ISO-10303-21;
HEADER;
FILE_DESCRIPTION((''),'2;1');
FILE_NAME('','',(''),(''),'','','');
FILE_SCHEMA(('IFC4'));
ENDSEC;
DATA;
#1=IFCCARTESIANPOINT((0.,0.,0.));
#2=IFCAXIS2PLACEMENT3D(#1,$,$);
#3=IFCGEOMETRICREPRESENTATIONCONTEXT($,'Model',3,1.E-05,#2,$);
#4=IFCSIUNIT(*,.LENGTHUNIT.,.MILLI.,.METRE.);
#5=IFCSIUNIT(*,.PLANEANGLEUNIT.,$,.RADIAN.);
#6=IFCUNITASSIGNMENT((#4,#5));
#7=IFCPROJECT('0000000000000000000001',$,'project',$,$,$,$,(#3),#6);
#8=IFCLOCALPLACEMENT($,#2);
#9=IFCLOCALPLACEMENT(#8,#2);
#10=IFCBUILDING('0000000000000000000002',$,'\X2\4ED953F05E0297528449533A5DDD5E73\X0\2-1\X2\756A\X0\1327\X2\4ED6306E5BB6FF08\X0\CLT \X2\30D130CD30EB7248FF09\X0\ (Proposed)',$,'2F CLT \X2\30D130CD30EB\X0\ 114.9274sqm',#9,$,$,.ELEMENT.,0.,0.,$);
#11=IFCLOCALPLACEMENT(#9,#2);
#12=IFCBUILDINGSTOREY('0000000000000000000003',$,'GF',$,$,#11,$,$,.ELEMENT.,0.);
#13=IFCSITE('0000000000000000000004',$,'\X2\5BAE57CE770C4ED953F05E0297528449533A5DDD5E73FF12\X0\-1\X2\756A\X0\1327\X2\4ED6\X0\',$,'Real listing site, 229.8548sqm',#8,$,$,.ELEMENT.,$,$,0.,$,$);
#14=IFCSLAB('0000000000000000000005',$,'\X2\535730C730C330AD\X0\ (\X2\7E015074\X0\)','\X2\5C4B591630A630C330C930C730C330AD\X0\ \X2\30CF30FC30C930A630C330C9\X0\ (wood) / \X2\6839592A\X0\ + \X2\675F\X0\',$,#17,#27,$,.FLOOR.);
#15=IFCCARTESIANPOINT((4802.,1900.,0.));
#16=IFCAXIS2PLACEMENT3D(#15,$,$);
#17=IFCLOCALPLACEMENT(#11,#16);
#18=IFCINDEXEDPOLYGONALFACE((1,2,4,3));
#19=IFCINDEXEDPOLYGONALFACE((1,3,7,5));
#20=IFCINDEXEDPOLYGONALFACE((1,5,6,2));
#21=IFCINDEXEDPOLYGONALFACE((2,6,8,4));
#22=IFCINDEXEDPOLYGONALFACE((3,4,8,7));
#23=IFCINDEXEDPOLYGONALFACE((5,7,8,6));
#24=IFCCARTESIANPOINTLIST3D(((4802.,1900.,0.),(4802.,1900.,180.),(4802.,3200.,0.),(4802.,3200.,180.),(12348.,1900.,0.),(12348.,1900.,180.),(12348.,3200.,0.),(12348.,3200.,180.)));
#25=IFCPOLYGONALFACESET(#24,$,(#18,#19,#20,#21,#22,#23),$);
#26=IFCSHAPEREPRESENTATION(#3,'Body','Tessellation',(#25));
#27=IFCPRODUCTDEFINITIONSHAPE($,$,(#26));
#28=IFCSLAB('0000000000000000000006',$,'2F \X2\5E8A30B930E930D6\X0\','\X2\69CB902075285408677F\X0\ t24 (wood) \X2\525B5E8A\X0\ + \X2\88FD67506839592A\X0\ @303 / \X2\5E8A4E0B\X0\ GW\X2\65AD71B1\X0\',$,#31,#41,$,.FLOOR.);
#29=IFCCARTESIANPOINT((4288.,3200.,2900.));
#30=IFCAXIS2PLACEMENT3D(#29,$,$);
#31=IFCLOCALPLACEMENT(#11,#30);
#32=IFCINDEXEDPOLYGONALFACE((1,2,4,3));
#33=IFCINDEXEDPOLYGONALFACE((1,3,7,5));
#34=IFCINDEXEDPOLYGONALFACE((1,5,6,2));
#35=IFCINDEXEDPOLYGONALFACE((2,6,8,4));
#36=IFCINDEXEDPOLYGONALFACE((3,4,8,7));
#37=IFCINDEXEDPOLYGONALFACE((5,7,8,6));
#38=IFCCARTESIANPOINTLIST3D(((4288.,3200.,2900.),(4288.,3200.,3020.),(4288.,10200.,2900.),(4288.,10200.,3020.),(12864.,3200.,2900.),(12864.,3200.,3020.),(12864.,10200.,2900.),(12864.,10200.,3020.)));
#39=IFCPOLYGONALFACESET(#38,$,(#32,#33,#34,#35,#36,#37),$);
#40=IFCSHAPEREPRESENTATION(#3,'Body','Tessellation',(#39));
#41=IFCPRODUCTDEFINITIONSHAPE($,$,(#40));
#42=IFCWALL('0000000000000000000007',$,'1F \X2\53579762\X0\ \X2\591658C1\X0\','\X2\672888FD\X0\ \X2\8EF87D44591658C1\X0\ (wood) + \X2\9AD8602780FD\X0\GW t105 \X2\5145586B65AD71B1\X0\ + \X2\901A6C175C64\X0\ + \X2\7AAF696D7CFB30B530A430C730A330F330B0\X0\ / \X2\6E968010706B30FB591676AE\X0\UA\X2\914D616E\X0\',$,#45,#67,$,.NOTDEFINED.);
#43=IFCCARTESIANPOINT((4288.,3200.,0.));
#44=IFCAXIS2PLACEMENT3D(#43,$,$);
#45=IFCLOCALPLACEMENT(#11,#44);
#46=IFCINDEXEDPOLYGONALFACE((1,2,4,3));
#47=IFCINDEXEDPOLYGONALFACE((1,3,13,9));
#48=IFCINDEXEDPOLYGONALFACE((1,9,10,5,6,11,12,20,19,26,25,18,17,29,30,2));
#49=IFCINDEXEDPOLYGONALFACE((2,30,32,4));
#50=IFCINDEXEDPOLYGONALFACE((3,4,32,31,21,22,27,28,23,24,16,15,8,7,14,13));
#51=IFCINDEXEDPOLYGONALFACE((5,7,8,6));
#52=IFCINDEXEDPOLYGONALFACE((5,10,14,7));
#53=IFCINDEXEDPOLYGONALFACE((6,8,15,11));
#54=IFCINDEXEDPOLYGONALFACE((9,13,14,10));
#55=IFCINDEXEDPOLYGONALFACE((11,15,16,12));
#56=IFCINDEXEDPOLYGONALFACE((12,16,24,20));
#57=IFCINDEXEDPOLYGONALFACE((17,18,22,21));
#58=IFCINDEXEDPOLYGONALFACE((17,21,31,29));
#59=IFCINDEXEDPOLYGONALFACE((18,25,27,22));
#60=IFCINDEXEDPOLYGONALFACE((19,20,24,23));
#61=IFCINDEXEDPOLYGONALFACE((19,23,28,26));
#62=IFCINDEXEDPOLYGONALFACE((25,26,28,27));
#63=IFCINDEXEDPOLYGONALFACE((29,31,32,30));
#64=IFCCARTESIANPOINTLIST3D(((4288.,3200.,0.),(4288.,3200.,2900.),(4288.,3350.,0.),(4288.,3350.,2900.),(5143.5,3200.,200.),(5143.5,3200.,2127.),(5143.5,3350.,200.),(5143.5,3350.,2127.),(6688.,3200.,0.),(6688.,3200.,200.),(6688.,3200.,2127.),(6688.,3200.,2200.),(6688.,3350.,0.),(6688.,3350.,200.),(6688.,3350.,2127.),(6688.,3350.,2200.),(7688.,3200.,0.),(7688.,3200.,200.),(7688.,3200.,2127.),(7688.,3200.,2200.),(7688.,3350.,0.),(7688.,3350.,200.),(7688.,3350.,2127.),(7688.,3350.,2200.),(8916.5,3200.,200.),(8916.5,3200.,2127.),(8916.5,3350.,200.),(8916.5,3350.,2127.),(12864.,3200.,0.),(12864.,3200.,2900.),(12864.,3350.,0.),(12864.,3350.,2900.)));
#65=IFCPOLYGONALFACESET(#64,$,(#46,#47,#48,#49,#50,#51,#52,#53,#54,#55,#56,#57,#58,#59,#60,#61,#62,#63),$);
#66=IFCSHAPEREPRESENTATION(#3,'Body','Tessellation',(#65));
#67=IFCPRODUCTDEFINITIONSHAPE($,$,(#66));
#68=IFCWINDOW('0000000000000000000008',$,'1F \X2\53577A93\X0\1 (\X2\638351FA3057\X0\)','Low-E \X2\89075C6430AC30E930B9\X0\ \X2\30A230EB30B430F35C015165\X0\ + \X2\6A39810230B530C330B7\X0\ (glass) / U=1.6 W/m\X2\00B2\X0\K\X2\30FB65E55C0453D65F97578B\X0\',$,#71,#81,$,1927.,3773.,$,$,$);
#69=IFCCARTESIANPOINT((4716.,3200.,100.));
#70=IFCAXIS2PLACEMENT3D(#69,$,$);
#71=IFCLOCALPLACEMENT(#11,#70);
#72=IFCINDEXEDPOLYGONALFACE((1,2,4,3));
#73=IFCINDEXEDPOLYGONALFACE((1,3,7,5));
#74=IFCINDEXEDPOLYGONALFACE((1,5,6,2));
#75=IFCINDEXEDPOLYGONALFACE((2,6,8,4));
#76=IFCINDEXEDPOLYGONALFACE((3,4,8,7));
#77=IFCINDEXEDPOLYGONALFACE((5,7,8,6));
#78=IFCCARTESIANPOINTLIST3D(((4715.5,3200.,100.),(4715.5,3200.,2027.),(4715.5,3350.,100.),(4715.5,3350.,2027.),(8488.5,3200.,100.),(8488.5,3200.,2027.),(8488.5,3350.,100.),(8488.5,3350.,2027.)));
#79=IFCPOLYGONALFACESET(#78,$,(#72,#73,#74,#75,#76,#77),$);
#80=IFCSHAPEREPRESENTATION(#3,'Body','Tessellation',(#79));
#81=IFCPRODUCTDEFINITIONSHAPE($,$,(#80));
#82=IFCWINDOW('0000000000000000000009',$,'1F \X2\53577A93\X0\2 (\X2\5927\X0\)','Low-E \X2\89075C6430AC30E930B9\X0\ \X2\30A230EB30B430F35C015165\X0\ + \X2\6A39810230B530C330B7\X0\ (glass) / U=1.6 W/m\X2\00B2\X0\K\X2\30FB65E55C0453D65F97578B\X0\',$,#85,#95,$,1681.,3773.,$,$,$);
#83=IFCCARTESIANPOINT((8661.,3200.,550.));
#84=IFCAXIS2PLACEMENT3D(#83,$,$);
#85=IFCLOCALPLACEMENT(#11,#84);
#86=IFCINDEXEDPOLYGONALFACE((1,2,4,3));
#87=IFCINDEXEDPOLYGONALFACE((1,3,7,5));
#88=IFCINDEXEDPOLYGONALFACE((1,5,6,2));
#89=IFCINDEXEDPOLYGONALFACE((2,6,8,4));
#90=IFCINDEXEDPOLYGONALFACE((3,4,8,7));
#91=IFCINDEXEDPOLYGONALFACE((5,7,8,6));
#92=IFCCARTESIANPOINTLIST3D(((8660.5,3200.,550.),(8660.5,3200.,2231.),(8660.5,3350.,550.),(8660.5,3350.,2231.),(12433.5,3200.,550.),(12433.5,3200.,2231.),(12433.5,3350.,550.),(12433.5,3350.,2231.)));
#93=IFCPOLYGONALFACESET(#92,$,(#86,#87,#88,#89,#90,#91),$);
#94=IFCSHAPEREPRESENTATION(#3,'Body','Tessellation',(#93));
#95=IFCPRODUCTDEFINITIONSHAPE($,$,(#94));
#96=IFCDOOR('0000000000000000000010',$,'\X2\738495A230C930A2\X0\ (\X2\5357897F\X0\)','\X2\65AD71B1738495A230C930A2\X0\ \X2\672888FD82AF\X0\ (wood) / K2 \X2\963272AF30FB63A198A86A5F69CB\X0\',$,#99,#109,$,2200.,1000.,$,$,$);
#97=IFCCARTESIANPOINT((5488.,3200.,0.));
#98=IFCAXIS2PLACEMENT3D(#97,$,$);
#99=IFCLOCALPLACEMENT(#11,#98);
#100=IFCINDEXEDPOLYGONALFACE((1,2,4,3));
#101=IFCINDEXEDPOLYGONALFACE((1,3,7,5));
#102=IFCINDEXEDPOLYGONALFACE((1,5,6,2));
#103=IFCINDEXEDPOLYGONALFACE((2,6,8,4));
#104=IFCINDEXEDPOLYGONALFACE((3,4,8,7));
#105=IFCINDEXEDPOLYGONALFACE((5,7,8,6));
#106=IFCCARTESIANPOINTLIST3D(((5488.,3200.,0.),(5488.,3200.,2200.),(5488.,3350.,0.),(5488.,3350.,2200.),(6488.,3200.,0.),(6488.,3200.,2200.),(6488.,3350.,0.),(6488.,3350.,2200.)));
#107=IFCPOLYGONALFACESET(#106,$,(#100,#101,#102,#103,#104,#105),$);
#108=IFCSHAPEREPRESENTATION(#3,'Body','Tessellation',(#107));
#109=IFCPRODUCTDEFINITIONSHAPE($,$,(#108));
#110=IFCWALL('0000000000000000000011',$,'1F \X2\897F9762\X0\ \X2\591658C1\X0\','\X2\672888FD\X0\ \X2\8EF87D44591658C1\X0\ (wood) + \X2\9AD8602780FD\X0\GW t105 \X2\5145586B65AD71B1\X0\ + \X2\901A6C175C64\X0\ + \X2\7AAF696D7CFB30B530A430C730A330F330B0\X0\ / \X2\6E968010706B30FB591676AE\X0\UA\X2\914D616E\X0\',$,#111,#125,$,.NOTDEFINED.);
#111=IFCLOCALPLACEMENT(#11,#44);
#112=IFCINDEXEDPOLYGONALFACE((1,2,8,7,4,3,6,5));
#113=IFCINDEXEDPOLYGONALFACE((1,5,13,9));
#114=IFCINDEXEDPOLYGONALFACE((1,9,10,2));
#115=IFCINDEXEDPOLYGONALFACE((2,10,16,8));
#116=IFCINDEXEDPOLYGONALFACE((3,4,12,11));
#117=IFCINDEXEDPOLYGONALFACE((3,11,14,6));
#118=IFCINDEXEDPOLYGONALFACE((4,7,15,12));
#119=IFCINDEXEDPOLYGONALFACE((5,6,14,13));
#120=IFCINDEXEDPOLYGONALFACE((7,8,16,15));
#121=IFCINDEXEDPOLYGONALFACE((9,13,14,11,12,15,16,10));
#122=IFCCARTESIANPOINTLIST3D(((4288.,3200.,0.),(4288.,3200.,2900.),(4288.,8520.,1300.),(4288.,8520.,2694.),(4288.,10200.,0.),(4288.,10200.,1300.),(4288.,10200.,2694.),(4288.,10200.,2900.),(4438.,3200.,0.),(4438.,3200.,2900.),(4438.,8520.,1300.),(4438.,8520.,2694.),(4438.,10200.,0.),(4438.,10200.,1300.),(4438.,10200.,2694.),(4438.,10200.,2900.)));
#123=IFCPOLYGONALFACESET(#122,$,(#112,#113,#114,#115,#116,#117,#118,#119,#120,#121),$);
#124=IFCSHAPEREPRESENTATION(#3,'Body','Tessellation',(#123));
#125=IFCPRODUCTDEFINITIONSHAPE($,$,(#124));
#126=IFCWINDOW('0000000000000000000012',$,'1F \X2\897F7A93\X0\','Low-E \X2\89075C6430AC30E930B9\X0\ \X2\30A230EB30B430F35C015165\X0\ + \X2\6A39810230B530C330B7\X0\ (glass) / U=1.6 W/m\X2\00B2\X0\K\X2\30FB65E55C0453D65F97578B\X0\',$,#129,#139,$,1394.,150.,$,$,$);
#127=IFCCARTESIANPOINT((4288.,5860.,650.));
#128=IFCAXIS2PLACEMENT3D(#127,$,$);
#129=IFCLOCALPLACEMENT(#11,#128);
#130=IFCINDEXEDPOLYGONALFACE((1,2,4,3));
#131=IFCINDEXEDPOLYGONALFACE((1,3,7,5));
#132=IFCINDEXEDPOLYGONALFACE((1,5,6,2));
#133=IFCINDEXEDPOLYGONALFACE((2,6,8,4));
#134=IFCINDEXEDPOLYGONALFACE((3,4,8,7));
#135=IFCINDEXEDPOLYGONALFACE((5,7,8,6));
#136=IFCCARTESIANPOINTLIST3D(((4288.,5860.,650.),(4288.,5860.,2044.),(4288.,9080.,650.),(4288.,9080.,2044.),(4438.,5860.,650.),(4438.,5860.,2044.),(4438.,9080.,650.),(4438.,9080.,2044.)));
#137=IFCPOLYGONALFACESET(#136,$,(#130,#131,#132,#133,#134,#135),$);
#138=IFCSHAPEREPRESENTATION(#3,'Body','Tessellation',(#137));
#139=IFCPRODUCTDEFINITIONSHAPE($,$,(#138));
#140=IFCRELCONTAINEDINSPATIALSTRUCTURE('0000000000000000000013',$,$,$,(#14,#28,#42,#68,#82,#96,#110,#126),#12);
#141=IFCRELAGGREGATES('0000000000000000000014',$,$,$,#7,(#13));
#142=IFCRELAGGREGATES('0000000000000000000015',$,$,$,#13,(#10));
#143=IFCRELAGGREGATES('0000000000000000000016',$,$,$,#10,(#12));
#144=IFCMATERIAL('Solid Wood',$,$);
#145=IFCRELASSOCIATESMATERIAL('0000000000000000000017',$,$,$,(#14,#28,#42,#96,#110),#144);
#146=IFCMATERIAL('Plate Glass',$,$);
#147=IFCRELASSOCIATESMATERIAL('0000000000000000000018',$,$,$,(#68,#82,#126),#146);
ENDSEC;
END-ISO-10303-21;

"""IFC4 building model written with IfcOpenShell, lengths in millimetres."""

from ifc_helpers import new_model, si_unit, frame, frame_2d, origin, place, context, project, spatial, rectangle, extrude, material, element, fill, save


model = new_model("IFC4")

# Units and contexts
model_context = context("Model", 3, precision=1e-05, world=origin())
ifc_project = project(units=[si_unit("LENGTHUNIT", "METRE", prefix="MILLI"), si_unit("PLANEANGLEUNIT", "RADIAN")], contexts=[model_context])

# Site, building, storey
site_placement = place(None, origin())
site = spatial("IfcSite", under=ifc_project, at=site_placement, Name="宮城県仙台市青葉区川平２-1番1327他", ObjectType="Real listing site, 229.8548sqm", CompositionType="ELEMENT", RefElevation=0.0)
building_placement = place(site_placement, origin())
building = spatial("IfcBuilding", under=site, at=building_placement, Name="仙台市青葉区川平2-1番1327他の家（CLT パネル版） (Proposed)", ObjectType="2F CLT パネル 114.9274sqm", CompositionType="ELEMENT", ElevationOfRefHeight=0.0, ElevationOfTerrain=0.0)
storey_placement = place(building_placement, origin())
storey = spatial("IfcBuildingStorey", under=building, at=storey_placement, Name="GF", CompositionType="ELEMENT", Elevation=0.0)

# Slabs
ifc_material_1 = material(Name="Solid Wood")
slab_1_placement = place(storey_placement, frame((4802.0, 1900.0, 0.0)))
element("IfcSlab", 1, at=slab_1_placement, inside=storey, material=ifc_material_1, Name="南デッキ (縁側)", Description="屋外ウッドデッキ ハードウッド (wood) / 根太 + 束", PredefinedType="FLOOR", context=model_context, shape_type="SweptSolid", body=[
    extrude(rectangle(XDim=7546.0, YDim=1300.0, at=frame_2d((3773.0, 650.0))), frame((4802.0, 1900.0, 0.0)), (0.0, 0.0, 1.0), 180.0),
])
slab_2_placement = place(storey_placement, frame((4288.0, 3200.0, 2900.0)))
element("IfcSlab", 2, at=slab_2_placement, inside=storey, material=ifc_material_1, Name="2F 床スラブ", Description="構造用合板 t24 (wood) 剛床 + 製材根太 @303 / 床下 GW断熱", PredefinedType="FLOOR", context=model_context, shape_type="SweptSolid", body=[
    extrude(rectangle(XDim=8576.0, YDim=7000.0, at=frame_2d((4288.0, 3500.0))), frame((4288.0, 3200.0, 2900.0)), (0.0, 0.0, 1.0), 120.0),
])

# Wall, openings, windows, door
wall_1_placement = place(storey_placement, frame((4288.0, 3200.0, 0.0)))
wall_1 = element("IfcWall", 3, at=wall_1_placement, inside=storey, material=ifc_material_1, Name="1F 南面 外壁", Description="木製 軸組外壁 (wood) + 高性能GW t105 充填断熱 + 通気層 + 窯業系サイディング / 準耐火・外皮UA配慮", PredefinedType="NOTDEFINED", context=model_context, shape_type="SweptSolid", body=[
    extrude(rectangle(XDim=8576.0, YDim=150.0, at=frame_2d((4288.0, 75.0))), frame((4288.0, 3200.0, 0.0)), (0.0, 0.0, 1.0), 2900.0),
])
opening_1_placement = place(storey_placement, frame((4716.0, 3200.0, 100.0)))
opening_1 = element("IfcOpeningElement", 4, at=opening_1_placement, cuts=wall_1, PredefinedType="NOTDEFINED", context=model_context, shape_type="SweptSolid", body=[
    extrude(rectangle(XDim=3773.0, YDim=150.0, at=frame_2d((1886.0, 75.0))), frame((4716.0, 3200.0, 100.0)), (0.0, 0.0, 1.0), 1927.0),
])
opening_2_placement = place(storey_placement, frame((8661.0, 3200.0, 550.0)))
opening_2 = element("IfcOpeningElement", 5, at=opening_2_placement, cuts=wall_1, PredefinedType="NOTDEFINED", context=model_context, shape_type="SweptSolid", body=[
    extrude(rectangle(XDim=3773.0, YDim=150.0, at=frame_2d((1886.0, 75.0))), frame((8661.0, 3200.0, 550.0)), (0.0, 0.0, 1.0), 1681.0),
])
opening_3_placement = place(storey_placement, frame((5488.0, 3200.0, 0.0)))
opening_3 = element("IfcOpeningElement", 6, at=opening_3_placement, cuts=wall_1, PredefinedType="NOTDEFINED", context=model_context, shape_type="SweptSolid", body=[
    extrude(rectangle(XDim=1000.0, YDim=150.0, at=frame_2d((500.0, 75.0))), frame((5488.0, 3200.0, 0.0)), (0.0, 0.0, 1.0), 2200.0),
])
ifc_material_2 = material(Name="Plate Glass")
window_1_placement = place(storey_placement, frame((4716.0, 3200.0, 100.0)))
window_1 = element("IfcWindow", 7, at=window_1_placement, inside=storey, material=ifc_material_2, Name="1F 南窓1 (掃出し)", Description="Low-E 複層ガラス アルゴン封入 + 樹脂サッシ (glass) / U=1.6 W/m²K・日射取得型", OverallHeight=1927.0, OverallWidth=3773.0, context=model_context, shape_type="SweptSolid", body=[
    extrude(rectangle(XDim=3773.0, YDim=150.0, at=frame_2d((1886.0, 75.0))), frame((4716.0, 3200.0, 100.0)), (0.0, 0.0, 1.0), 1927.0),
])
fill(opening_1, window_1)
window_2_placement = place(storey_placement, frame((8661.0, 3200.0, 550.0)))
window_2 = element("IfcWindow", 8, at=window_2_placement, inside=storey, material=ifc_material_2, Name="1F 南窓2 (大)", Description="Low-E 複層ガラス アルゴン封入 + 樹脂サッシ (glass) / U=1.6 W/m²K・日射取得型", OverallHeight=1681.0, OverallWidth=3773.0, context=model_context, shape_type="SweptSolid", body=[
    extrude(rectangle(XDim=3773.0, YDim=150.0, at=frame_2d((1886.0, 75.0))), frame((8661.0, 3200.0, 550.0)), (0.0, 0.0, 1.0), 1681.0),
])
fill(opening_2, window_2)
door_placement = place(storey_placement, frame((5488.0, 3200.0, 0.0)))
door = element("IfcDoor", 9, at=door_placement, inside=storey, material=ifc_material_1, Name="玄関ドア (南西)", Description="断熱玄関ドア 木製芯 (wood) / K2 防犯・採風機構", OverallHeight=2200.0, OverallWidth=1000.0, context=model_context, shape_type="SweptSolid", body=[
    extrude(rectangle(XDim=1000.0, YDim=150.0, at=frame_2d((500.0, 75.0))), frame((5488.0, 3200.0, 0.0)), (0.0, 0.0, 1.0), 2200.0),
])
fill(opening_3, door)

# Wall, opening, window
wall_2_placement = place(storey_placement, frame((4288.0, 3200.0, 0.0)))
wall_2 = element("IfcWall", 10, at=wall_2_placement, inside=storey, material=ifc_material_1, Name="1F 西面 外壁", Description="木製 軸組外壁 (wood) + 高性能GW t105 充填断熱 + 通気層 + 窯業系サイディング / 準耐火・外皮UA配慮", PredefinedType="NOTDEFINED", context=model_context, shape_type="SweptSolid", body=[
    extrude(rectangle(XDim=150.0, YDim=7000.0, at=frame_2d((75.0, 3500.0))), frame((4288.0, 3200.0, 0.0)), (0.0, 0.0, 1.0), 2900.0),
])
opening_4_placement = place(storey_placement, frame((4288.0, 5860.0, 650.0)))
opening_4 = element("IfcOpeningElement", 11, at=opening_4_placement, cuts=wall_2, PredefinedType="NOTDEFINED", context=model_context, shape_type="SweptSolid", body=[
    extrude(rectangle(XDim=150.0, YDim=3220.0, at=frame_2d((75.0, 1610.0))), frame((4288.0, 5860.0, 650.0)), (0.0, 0.0, 1.0), 1394.0),
])
window_3_placement = place(storey_placement, frame((4288.0, 5860.0, 650.0)))
window_3 = element("IfcWindow", 12, at=window_3_placement, inside=storey, material=ifc_material_2, Name="1F 西窓", Description="Low-E 複層ガラス アルゴン封入 + 樹脂サッシ (glass) / U=1.6 W/m²K・日射取得型", OverallHeight=1394.0, OverallWidth=150.0, context=model_context, shape_type="SweptSolid", body=[
    extrude(rectangle(XDim=150.0, YDim=3220.0, at=frame_2d((75.0, 1610.0))), frame((4288.0, 5860.0, 650.0)), (0.0, 0.0, 1.0), 1394.0),
])
fill(opening_4, window_3)

save(model, "model.ifc")
